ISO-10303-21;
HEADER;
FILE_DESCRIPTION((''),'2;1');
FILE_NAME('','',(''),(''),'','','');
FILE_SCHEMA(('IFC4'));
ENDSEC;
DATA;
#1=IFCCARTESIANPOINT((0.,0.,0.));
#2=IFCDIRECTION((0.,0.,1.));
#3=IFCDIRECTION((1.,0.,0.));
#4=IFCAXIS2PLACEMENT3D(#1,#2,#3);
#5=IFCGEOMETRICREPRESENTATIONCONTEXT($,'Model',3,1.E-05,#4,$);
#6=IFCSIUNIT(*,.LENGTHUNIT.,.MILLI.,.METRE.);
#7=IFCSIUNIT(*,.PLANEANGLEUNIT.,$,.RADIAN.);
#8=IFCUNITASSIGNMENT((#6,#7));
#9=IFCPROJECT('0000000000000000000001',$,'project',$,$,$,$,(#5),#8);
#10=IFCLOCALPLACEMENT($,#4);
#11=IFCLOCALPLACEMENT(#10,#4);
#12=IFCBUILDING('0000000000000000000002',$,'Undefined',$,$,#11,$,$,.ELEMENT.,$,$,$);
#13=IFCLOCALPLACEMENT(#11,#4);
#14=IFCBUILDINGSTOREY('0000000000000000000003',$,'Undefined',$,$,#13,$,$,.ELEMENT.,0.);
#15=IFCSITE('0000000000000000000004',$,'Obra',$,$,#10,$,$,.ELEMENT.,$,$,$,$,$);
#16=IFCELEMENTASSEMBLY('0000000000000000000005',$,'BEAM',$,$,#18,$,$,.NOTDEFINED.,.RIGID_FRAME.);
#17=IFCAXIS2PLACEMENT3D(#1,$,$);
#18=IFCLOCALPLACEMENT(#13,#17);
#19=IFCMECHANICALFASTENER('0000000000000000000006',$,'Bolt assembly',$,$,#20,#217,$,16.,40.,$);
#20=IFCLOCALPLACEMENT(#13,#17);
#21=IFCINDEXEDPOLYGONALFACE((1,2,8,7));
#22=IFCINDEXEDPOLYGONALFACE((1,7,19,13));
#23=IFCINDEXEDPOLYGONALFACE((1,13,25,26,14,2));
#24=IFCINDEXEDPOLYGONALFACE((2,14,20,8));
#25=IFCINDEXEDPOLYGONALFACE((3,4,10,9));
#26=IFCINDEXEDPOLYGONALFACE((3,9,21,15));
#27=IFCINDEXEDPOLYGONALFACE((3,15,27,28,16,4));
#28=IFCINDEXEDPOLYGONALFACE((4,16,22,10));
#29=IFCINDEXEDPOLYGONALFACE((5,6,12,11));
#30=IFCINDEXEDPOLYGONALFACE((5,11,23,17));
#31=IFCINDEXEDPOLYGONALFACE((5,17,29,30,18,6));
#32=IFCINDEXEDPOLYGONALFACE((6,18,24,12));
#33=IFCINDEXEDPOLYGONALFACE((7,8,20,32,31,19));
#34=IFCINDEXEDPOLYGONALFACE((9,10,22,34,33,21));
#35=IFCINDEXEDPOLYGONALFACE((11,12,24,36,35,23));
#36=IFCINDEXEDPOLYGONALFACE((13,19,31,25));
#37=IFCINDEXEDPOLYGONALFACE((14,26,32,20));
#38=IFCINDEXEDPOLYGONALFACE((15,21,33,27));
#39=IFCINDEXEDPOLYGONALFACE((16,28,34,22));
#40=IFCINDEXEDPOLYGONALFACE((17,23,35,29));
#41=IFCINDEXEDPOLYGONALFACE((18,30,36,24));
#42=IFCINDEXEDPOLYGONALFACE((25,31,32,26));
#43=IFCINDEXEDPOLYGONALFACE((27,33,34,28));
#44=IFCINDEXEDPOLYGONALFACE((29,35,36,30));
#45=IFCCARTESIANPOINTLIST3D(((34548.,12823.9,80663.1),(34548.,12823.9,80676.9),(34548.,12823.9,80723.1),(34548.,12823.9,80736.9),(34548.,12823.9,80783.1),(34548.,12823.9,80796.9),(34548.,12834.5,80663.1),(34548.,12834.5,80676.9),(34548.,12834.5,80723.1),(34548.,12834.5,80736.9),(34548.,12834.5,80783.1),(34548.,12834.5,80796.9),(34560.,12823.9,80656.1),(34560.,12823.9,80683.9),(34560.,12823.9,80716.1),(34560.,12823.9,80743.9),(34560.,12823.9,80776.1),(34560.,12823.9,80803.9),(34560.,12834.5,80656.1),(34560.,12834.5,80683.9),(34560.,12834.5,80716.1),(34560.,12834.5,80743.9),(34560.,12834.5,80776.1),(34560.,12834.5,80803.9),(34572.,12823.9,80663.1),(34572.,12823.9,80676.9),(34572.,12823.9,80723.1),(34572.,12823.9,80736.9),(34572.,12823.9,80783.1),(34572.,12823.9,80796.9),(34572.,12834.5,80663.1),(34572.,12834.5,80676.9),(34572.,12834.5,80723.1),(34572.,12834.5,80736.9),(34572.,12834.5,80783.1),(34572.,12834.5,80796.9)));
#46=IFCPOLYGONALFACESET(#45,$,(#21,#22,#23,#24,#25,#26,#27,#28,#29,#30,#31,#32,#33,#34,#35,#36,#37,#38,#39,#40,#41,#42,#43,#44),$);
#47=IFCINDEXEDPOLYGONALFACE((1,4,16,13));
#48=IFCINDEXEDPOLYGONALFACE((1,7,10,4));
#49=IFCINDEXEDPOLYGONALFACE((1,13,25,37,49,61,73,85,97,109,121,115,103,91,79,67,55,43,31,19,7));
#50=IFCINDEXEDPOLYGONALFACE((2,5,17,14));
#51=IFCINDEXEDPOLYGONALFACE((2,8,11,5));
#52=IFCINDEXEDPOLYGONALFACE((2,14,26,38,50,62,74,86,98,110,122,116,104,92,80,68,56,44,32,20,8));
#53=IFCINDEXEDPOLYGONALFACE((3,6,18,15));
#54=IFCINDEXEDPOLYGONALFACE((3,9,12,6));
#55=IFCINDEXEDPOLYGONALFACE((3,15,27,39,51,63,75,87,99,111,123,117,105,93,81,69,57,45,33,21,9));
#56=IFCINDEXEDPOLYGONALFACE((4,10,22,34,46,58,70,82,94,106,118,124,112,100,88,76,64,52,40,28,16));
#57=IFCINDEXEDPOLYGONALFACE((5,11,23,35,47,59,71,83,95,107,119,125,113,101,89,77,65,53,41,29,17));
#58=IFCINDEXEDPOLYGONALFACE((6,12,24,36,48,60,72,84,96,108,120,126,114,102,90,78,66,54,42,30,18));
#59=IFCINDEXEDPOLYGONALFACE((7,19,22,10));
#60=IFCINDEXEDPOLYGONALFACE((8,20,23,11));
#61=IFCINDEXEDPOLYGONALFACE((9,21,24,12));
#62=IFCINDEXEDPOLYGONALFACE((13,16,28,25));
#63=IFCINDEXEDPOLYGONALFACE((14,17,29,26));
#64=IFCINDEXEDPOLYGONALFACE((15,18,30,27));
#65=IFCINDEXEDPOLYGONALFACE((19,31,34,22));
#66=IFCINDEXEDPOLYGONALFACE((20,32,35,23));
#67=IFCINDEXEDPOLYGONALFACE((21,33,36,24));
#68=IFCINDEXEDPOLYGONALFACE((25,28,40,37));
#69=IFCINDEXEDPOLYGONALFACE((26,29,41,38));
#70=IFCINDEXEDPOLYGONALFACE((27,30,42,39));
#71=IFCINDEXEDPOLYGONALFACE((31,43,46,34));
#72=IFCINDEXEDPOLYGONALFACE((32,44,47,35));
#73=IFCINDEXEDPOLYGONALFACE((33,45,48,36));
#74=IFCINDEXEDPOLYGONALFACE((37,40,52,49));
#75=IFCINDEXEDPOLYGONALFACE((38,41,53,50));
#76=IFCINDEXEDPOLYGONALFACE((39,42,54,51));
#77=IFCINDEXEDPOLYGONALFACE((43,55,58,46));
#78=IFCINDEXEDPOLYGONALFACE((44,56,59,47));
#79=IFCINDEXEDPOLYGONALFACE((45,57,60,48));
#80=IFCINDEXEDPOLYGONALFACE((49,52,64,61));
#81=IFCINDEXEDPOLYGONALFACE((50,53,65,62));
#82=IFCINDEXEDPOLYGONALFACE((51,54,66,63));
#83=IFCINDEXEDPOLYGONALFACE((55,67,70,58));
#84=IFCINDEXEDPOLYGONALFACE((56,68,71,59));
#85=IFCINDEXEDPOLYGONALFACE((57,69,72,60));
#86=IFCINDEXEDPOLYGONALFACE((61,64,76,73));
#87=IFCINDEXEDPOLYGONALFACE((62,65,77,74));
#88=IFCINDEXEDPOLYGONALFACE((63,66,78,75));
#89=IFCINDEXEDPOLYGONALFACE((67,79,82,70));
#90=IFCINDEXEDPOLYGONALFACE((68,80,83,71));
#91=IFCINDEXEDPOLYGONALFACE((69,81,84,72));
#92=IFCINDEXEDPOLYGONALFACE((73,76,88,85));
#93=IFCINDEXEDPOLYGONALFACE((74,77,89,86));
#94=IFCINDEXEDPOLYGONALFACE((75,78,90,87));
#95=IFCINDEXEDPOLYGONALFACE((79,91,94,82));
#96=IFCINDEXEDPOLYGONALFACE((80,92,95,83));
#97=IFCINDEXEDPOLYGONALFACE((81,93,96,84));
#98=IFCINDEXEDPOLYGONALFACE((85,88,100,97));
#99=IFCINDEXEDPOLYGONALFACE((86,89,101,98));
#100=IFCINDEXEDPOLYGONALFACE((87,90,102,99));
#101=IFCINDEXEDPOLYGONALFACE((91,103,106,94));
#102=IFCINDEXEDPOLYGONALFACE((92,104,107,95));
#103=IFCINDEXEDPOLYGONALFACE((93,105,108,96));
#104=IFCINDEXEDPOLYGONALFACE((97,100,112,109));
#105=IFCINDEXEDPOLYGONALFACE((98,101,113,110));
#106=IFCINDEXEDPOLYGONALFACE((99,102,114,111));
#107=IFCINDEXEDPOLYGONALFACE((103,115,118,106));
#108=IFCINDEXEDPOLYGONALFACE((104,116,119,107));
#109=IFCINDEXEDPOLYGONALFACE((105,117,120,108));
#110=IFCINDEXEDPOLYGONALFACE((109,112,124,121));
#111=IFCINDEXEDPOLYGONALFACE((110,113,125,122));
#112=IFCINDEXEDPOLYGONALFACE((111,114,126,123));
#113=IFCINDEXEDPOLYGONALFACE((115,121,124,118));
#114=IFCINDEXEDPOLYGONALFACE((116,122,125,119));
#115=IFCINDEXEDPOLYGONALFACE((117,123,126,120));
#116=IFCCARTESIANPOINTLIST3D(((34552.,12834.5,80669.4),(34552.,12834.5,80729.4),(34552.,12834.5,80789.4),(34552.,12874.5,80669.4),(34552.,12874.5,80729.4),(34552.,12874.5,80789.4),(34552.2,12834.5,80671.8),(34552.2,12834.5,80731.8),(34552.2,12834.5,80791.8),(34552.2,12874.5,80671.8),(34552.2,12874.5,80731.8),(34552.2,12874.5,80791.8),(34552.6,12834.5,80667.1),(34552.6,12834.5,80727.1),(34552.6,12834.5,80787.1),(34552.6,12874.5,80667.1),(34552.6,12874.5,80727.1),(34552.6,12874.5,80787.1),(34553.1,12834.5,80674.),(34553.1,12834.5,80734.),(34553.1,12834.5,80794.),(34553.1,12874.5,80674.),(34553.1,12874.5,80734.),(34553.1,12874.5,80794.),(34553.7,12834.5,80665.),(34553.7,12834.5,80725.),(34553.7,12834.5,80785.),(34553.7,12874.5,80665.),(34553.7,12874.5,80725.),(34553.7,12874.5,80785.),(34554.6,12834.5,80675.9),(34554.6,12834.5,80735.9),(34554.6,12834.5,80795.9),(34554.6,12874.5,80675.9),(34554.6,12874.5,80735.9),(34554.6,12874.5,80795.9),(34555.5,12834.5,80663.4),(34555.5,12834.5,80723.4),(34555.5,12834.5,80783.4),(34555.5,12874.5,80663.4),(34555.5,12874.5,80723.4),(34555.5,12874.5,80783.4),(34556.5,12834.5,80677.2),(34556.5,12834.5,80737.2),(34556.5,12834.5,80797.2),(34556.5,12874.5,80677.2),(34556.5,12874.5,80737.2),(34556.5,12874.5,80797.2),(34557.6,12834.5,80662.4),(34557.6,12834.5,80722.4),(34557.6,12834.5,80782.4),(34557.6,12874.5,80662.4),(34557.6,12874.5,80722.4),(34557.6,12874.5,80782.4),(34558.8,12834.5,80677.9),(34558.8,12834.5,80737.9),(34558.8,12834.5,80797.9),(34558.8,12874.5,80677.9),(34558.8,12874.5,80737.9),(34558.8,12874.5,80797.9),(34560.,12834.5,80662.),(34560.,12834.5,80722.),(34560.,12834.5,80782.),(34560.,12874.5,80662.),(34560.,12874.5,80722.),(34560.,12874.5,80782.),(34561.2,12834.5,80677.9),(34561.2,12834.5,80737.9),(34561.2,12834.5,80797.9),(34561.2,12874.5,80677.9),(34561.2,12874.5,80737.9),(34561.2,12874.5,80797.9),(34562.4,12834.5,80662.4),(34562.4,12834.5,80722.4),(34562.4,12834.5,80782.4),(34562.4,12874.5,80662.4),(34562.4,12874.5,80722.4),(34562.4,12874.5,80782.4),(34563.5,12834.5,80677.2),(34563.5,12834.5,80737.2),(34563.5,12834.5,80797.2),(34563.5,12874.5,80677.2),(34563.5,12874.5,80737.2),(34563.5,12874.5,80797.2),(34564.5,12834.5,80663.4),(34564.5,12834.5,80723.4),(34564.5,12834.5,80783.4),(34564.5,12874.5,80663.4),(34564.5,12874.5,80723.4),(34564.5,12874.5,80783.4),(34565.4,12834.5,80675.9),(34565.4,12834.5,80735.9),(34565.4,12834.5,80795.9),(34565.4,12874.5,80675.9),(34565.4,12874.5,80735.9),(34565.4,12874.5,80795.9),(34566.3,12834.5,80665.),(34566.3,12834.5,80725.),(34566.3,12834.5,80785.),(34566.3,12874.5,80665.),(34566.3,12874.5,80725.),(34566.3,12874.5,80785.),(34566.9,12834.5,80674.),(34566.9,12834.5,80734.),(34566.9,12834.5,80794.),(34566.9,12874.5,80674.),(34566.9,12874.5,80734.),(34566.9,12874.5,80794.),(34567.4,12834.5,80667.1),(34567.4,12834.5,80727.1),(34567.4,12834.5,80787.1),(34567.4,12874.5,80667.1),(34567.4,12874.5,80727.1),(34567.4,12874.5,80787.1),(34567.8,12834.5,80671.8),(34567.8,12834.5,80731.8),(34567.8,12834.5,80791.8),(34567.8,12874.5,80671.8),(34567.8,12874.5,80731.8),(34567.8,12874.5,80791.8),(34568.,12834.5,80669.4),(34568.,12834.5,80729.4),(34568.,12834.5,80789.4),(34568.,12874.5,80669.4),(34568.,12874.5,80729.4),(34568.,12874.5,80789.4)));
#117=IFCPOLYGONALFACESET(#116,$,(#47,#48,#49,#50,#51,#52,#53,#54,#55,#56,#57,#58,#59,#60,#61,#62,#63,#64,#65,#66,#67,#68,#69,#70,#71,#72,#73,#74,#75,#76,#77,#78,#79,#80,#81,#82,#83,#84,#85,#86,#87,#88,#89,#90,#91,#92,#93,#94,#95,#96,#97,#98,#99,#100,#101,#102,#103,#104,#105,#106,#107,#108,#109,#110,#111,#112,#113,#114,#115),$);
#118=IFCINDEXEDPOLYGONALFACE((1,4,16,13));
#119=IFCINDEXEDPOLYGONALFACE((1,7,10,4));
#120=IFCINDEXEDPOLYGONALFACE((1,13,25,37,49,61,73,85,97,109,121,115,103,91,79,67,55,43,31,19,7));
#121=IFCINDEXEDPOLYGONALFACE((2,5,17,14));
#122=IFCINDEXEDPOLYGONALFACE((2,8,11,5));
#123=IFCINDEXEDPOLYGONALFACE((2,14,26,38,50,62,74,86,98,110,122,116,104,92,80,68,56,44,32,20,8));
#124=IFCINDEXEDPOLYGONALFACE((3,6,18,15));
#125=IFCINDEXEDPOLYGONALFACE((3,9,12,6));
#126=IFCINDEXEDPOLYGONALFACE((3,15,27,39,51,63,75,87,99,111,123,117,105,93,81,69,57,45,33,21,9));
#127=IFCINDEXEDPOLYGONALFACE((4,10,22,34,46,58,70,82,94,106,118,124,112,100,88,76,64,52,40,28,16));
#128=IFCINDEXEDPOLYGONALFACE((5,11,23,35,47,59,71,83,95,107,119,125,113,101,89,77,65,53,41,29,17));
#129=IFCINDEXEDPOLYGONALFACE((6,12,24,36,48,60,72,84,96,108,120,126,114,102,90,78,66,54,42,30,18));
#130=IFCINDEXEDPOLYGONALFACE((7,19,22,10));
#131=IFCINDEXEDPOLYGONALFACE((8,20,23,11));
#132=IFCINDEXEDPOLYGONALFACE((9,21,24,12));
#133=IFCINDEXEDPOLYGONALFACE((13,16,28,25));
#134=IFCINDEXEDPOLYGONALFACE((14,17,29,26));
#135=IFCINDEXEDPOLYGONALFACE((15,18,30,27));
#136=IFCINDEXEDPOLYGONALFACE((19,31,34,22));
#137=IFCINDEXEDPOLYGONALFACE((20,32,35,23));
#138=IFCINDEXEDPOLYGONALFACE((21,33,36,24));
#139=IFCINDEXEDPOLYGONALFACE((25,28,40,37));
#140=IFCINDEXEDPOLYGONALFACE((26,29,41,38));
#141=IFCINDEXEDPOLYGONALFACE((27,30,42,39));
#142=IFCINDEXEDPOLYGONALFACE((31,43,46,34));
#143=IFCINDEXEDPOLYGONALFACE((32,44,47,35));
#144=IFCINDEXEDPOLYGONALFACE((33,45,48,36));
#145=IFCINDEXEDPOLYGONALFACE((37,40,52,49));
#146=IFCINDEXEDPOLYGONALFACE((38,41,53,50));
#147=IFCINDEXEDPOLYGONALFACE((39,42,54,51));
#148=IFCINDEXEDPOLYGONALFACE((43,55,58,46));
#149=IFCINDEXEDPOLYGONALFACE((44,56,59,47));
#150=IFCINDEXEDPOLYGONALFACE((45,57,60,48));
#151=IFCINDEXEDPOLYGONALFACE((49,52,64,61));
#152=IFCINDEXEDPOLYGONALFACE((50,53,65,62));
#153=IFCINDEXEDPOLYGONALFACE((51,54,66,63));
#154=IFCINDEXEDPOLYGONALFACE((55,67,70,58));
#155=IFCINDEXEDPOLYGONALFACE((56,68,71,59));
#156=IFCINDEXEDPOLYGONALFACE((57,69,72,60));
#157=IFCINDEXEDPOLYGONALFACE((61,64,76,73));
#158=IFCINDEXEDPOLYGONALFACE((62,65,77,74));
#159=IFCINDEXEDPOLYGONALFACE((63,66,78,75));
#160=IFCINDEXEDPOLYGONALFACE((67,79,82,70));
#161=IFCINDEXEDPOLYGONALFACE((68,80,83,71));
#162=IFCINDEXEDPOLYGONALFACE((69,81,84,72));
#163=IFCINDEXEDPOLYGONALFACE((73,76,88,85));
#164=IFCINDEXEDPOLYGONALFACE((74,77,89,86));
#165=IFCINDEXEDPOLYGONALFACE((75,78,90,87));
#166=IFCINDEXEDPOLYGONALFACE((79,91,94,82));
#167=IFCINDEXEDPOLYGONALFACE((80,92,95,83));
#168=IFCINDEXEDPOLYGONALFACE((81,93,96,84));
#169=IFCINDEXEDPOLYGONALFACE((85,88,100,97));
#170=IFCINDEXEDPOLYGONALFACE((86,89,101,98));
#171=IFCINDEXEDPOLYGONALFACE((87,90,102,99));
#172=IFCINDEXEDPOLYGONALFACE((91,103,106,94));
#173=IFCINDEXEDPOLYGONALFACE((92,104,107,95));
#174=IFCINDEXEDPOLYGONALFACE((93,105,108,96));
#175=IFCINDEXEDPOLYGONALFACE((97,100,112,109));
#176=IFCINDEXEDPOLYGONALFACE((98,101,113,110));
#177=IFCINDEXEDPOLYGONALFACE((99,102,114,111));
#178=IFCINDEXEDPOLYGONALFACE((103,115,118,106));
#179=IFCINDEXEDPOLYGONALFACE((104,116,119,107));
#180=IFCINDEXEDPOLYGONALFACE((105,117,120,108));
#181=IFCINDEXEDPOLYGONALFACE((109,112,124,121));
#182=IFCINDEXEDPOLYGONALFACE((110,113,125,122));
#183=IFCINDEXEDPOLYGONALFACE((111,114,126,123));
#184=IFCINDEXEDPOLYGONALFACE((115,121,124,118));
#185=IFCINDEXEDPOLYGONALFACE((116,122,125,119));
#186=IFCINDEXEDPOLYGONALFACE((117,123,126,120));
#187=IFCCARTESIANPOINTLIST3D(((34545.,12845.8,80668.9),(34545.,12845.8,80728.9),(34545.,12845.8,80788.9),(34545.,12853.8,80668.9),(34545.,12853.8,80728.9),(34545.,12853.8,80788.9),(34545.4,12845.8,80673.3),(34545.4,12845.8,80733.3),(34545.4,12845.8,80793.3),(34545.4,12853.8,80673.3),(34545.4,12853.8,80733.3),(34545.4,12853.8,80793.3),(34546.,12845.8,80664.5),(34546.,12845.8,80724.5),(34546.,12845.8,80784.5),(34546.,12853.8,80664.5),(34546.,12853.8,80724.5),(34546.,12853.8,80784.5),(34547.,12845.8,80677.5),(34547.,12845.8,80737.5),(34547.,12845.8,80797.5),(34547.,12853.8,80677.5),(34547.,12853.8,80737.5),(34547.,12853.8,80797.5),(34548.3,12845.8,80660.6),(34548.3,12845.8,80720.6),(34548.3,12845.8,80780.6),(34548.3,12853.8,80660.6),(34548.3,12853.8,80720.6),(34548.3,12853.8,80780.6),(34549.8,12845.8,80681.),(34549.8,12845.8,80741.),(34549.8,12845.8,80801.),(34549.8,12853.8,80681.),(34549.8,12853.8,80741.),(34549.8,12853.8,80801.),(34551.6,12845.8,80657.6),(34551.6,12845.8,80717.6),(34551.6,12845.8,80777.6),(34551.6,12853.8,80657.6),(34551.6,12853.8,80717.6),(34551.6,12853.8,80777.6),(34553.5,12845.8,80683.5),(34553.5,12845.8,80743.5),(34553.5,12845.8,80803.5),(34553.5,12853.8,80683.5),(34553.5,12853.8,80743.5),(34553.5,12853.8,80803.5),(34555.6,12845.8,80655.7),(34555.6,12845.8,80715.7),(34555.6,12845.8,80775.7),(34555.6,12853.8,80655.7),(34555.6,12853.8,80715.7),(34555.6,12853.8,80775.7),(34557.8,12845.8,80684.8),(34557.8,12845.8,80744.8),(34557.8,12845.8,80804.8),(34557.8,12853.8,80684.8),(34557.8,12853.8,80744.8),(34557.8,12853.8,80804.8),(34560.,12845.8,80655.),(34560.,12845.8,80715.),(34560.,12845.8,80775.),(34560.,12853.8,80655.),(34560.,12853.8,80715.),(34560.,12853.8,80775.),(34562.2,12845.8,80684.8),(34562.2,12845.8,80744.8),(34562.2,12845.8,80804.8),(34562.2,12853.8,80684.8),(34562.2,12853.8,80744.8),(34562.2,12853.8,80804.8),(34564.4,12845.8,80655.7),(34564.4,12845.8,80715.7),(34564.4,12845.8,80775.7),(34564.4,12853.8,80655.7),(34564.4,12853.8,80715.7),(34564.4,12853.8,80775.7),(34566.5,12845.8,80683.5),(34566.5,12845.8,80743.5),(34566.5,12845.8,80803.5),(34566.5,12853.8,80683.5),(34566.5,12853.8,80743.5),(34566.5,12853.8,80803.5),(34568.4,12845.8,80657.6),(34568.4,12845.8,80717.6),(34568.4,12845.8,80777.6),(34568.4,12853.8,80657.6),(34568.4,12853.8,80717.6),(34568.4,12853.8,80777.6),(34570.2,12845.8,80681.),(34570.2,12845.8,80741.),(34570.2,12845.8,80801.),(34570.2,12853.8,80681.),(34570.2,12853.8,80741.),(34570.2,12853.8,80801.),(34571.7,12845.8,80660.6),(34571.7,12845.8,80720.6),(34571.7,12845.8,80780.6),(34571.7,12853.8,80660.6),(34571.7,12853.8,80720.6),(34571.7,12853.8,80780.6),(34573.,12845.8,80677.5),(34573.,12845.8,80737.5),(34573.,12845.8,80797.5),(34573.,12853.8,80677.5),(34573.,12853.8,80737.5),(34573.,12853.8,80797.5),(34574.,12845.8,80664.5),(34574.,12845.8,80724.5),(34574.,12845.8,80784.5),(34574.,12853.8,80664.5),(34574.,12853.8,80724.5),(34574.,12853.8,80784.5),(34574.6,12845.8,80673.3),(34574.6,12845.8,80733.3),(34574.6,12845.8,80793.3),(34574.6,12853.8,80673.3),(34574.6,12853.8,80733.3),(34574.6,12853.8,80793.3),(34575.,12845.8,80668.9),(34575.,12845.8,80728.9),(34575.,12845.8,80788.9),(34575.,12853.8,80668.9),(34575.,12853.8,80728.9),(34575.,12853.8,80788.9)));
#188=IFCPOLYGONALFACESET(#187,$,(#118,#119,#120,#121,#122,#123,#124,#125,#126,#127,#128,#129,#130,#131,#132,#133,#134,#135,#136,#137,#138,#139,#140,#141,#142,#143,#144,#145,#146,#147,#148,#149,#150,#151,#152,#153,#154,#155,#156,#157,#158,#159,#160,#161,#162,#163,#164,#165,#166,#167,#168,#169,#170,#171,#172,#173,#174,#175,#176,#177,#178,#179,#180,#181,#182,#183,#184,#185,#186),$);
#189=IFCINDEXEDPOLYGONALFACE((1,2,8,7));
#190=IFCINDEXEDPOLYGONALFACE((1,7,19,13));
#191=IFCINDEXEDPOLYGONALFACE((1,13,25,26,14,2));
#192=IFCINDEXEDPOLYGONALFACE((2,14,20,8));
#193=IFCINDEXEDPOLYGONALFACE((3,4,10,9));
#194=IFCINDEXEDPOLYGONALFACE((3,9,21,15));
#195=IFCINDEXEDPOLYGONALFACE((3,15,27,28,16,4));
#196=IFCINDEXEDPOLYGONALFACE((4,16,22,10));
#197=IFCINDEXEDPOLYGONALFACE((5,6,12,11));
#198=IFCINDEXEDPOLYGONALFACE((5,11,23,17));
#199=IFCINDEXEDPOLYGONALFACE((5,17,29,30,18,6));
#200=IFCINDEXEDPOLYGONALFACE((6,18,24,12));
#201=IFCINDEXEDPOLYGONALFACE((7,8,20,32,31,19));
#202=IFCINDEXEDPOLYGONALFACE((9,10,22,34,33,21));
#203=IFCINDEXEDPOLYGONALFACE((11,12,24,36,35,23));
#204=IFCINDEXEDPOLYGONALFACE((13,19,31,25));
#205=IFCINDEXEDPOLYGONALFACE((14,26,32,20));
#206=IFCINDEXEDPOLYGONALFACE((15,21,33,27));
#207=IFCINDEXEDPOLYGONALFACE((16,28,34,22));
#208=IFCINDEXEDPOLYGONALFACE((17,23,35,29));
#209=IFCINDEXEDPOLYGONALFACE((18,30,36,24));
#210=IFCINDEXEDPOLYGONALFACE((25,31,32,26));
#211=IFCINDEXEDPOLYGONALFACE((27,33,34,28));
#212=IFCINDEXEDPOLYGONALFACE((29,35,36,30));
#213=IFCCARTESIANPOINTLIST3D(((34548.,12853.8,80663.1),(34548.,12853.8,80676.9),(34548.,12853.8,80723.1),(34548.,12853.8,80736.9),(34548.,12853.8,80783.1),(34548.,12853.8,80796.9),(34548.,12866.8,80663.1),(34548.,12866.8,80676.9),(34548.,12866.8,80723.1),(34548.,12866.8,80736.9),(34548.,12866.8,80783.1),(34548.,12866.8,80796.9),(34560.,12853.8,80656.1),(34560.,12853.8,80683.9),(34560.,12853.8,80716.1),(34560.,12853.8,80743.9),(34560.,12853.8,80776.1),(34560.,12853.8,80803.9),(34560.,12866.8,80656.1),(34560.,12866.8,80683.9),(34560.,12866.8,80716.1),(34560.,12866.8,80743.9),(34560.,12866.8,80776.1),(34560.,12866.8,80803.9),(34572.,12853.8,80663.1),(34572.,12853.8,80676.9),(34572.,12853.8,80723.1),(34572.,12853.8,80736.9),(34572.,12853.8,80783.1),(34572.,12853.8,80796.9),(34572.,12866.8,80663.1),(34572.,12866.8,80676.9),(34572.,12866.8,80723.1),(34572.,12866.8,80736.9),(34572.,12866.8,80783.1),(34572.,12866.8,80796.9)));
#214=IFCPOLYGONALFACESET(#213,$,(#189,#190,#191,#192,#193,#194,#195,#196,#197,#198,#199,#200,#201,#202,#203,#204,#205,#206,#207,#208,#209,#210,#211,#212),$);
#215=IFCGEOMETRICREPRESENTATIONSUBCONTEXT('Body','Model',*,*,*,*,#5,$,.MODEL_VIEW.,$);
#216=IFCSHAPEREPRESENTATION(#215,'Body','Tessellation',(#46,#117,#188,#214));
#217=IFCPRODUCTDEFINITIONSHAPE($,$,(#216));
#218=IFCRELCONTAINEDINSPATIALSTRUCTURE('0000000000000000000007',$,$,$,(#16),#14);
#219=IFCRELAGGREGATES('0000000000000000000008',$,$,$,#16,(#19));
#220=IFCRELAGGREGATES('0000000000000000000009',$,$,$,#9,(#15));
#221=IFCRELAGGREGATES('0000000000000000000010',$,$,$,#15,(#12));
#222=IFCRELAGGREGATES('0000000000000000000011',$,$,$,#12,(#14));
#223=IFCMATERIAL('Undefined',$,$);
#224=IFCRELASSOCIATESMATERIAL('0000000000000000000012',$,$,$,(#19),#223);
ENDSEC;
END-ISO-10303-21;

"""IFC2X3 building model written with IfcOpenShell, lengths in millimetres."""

from ifc_helpers import new_model, si_unit, frame, origin_with_axes, origin_2d_with_axis, place, context, subcontext, project, spatial, polyline, circle, outline, extrude, source, transform, mapped, material, element, aggregate, save


model = new_model("IFC2X3")

# Units and contexts
model_context = context("Model", 3, precision=1e-05, world=origin_with_axes())
body_context = subcontext(model_context, "Body", "Model", "MODEL_VIEW")
ifc_project = project(units=[si_unit("LENGTHUNIT", "METRE", prefix="MILLI"), si_unit("PLANEANGLEUNIT", "RADIAN")], contexts=[model_context])

# Site, building, storey
site_placement = place(None, origin_with_axes())
site = spatial("IfcSite", under=ifc_project, at=site_placement, Name="Obra", CompositionType="ELEMENT")
building_placement = place(site_placement, origin_with_axes())
building = spatial("IfcBuilding", under=site, at=building_placement, Name="Undefined", CompositionType="ELEMENT")
storey_placement = place(building_placement, origin_with_axes())
storey = spatial("IfcBuildingStorey", under=building, at=storey_placement, Name="Undefined", CompositionType="ELEMENT", Elevation=0.0)

# Shared definitions
ifc_material_1 = material(Name="Undefined")

# Element assembly, mechanical fastener
assembly_1_placement = place(storey_placement, origin_with_axes())
assembly_1 = element("IfcElementAssembly", 1, at=assembly_1_placement, inside=storey, Name="BEAM", AssemblyPlace="NOTDEFINED", PredefinedType="RIGID_FRAME")
shared_shape_1 = source(origin_with_axes(), body_context, "Body", "SweptSolid", [
    extrude(outline(polyline([(13.9, 0.0), (6.9, 12.0), (-6.9, 12.0), (-13.9, 0.0), (-6.9, -12.0), (6.9, -12.0), (13.9, 0.0)])), frame((0.0, -19.7, 0.0), z_axis=(0.0, 1.0, 0.0), x_axis=(1.0, 0.0, 0.0)), (0.0, 0.0, 1.0), 10.6),
    extrude(circle(Radius=8.0, at=origin_2d_with_axis()), frame((0.0, -9.1, 0.0), z_axis=(0.0, 1.0, 0.0), x_axis=(1.0, 0.0, 0.0)), (0.0, 0.0, 1.0), 40.0),
    extrude(circle(Radius=15.0, at=origin_2d_with_axis()), frame((0.0, 2.2, 0.0), z_axis=(0.0, 1.0, 0.0), x_axis=(1.0, 0.0, 0.0)), (0.0, 0.0, 1.0), 8.0),
    extrude(outline(polyline([(13.9, 0.0), (6.9, 12.0), (-6.9, 12.0), (-13.9, 0.0), (-6.9, -12.0), (6.9, -12.0), (13.9, 0.0)])), frame((0.0, 10.2, 0.0), z_axis=(0.0, 1.0, 0.0), x_axis=(1.0, 0.0, 0.0)), (0.0, 0.0, 1.0), 13.0),
])
mechanical_fastener_1_placement = place(assembly_1_placement, frame((34510.0, 12843.6, 80850.0), z_axis=(1.0, 0.0, 0.0), x_axis=(0.0, 0.0, -1.0)))
mechanical_fastener_1 = element("IfcMechanicalFastener", 2, at=mechanical_fastener_1_placement, material=ifc_material_1, Name="Bolt assembly", NominalDiameter=16.0, NominalLength=40.0, context=body_context, shape_type="MappedRepresentation", body=[
    mapped(shared_shape_1, transform((60.0, 0.0, 50.0))),
    mapped(shared_shape_1, transform((120.0, 0.0, 50.0))),
    mapped(shared_shape_1, transform((180.0, 0.0, 50.0))),
])
aggregate(assembly_1, [mechanical_fastener_1])

save(model, "model.ifc")
